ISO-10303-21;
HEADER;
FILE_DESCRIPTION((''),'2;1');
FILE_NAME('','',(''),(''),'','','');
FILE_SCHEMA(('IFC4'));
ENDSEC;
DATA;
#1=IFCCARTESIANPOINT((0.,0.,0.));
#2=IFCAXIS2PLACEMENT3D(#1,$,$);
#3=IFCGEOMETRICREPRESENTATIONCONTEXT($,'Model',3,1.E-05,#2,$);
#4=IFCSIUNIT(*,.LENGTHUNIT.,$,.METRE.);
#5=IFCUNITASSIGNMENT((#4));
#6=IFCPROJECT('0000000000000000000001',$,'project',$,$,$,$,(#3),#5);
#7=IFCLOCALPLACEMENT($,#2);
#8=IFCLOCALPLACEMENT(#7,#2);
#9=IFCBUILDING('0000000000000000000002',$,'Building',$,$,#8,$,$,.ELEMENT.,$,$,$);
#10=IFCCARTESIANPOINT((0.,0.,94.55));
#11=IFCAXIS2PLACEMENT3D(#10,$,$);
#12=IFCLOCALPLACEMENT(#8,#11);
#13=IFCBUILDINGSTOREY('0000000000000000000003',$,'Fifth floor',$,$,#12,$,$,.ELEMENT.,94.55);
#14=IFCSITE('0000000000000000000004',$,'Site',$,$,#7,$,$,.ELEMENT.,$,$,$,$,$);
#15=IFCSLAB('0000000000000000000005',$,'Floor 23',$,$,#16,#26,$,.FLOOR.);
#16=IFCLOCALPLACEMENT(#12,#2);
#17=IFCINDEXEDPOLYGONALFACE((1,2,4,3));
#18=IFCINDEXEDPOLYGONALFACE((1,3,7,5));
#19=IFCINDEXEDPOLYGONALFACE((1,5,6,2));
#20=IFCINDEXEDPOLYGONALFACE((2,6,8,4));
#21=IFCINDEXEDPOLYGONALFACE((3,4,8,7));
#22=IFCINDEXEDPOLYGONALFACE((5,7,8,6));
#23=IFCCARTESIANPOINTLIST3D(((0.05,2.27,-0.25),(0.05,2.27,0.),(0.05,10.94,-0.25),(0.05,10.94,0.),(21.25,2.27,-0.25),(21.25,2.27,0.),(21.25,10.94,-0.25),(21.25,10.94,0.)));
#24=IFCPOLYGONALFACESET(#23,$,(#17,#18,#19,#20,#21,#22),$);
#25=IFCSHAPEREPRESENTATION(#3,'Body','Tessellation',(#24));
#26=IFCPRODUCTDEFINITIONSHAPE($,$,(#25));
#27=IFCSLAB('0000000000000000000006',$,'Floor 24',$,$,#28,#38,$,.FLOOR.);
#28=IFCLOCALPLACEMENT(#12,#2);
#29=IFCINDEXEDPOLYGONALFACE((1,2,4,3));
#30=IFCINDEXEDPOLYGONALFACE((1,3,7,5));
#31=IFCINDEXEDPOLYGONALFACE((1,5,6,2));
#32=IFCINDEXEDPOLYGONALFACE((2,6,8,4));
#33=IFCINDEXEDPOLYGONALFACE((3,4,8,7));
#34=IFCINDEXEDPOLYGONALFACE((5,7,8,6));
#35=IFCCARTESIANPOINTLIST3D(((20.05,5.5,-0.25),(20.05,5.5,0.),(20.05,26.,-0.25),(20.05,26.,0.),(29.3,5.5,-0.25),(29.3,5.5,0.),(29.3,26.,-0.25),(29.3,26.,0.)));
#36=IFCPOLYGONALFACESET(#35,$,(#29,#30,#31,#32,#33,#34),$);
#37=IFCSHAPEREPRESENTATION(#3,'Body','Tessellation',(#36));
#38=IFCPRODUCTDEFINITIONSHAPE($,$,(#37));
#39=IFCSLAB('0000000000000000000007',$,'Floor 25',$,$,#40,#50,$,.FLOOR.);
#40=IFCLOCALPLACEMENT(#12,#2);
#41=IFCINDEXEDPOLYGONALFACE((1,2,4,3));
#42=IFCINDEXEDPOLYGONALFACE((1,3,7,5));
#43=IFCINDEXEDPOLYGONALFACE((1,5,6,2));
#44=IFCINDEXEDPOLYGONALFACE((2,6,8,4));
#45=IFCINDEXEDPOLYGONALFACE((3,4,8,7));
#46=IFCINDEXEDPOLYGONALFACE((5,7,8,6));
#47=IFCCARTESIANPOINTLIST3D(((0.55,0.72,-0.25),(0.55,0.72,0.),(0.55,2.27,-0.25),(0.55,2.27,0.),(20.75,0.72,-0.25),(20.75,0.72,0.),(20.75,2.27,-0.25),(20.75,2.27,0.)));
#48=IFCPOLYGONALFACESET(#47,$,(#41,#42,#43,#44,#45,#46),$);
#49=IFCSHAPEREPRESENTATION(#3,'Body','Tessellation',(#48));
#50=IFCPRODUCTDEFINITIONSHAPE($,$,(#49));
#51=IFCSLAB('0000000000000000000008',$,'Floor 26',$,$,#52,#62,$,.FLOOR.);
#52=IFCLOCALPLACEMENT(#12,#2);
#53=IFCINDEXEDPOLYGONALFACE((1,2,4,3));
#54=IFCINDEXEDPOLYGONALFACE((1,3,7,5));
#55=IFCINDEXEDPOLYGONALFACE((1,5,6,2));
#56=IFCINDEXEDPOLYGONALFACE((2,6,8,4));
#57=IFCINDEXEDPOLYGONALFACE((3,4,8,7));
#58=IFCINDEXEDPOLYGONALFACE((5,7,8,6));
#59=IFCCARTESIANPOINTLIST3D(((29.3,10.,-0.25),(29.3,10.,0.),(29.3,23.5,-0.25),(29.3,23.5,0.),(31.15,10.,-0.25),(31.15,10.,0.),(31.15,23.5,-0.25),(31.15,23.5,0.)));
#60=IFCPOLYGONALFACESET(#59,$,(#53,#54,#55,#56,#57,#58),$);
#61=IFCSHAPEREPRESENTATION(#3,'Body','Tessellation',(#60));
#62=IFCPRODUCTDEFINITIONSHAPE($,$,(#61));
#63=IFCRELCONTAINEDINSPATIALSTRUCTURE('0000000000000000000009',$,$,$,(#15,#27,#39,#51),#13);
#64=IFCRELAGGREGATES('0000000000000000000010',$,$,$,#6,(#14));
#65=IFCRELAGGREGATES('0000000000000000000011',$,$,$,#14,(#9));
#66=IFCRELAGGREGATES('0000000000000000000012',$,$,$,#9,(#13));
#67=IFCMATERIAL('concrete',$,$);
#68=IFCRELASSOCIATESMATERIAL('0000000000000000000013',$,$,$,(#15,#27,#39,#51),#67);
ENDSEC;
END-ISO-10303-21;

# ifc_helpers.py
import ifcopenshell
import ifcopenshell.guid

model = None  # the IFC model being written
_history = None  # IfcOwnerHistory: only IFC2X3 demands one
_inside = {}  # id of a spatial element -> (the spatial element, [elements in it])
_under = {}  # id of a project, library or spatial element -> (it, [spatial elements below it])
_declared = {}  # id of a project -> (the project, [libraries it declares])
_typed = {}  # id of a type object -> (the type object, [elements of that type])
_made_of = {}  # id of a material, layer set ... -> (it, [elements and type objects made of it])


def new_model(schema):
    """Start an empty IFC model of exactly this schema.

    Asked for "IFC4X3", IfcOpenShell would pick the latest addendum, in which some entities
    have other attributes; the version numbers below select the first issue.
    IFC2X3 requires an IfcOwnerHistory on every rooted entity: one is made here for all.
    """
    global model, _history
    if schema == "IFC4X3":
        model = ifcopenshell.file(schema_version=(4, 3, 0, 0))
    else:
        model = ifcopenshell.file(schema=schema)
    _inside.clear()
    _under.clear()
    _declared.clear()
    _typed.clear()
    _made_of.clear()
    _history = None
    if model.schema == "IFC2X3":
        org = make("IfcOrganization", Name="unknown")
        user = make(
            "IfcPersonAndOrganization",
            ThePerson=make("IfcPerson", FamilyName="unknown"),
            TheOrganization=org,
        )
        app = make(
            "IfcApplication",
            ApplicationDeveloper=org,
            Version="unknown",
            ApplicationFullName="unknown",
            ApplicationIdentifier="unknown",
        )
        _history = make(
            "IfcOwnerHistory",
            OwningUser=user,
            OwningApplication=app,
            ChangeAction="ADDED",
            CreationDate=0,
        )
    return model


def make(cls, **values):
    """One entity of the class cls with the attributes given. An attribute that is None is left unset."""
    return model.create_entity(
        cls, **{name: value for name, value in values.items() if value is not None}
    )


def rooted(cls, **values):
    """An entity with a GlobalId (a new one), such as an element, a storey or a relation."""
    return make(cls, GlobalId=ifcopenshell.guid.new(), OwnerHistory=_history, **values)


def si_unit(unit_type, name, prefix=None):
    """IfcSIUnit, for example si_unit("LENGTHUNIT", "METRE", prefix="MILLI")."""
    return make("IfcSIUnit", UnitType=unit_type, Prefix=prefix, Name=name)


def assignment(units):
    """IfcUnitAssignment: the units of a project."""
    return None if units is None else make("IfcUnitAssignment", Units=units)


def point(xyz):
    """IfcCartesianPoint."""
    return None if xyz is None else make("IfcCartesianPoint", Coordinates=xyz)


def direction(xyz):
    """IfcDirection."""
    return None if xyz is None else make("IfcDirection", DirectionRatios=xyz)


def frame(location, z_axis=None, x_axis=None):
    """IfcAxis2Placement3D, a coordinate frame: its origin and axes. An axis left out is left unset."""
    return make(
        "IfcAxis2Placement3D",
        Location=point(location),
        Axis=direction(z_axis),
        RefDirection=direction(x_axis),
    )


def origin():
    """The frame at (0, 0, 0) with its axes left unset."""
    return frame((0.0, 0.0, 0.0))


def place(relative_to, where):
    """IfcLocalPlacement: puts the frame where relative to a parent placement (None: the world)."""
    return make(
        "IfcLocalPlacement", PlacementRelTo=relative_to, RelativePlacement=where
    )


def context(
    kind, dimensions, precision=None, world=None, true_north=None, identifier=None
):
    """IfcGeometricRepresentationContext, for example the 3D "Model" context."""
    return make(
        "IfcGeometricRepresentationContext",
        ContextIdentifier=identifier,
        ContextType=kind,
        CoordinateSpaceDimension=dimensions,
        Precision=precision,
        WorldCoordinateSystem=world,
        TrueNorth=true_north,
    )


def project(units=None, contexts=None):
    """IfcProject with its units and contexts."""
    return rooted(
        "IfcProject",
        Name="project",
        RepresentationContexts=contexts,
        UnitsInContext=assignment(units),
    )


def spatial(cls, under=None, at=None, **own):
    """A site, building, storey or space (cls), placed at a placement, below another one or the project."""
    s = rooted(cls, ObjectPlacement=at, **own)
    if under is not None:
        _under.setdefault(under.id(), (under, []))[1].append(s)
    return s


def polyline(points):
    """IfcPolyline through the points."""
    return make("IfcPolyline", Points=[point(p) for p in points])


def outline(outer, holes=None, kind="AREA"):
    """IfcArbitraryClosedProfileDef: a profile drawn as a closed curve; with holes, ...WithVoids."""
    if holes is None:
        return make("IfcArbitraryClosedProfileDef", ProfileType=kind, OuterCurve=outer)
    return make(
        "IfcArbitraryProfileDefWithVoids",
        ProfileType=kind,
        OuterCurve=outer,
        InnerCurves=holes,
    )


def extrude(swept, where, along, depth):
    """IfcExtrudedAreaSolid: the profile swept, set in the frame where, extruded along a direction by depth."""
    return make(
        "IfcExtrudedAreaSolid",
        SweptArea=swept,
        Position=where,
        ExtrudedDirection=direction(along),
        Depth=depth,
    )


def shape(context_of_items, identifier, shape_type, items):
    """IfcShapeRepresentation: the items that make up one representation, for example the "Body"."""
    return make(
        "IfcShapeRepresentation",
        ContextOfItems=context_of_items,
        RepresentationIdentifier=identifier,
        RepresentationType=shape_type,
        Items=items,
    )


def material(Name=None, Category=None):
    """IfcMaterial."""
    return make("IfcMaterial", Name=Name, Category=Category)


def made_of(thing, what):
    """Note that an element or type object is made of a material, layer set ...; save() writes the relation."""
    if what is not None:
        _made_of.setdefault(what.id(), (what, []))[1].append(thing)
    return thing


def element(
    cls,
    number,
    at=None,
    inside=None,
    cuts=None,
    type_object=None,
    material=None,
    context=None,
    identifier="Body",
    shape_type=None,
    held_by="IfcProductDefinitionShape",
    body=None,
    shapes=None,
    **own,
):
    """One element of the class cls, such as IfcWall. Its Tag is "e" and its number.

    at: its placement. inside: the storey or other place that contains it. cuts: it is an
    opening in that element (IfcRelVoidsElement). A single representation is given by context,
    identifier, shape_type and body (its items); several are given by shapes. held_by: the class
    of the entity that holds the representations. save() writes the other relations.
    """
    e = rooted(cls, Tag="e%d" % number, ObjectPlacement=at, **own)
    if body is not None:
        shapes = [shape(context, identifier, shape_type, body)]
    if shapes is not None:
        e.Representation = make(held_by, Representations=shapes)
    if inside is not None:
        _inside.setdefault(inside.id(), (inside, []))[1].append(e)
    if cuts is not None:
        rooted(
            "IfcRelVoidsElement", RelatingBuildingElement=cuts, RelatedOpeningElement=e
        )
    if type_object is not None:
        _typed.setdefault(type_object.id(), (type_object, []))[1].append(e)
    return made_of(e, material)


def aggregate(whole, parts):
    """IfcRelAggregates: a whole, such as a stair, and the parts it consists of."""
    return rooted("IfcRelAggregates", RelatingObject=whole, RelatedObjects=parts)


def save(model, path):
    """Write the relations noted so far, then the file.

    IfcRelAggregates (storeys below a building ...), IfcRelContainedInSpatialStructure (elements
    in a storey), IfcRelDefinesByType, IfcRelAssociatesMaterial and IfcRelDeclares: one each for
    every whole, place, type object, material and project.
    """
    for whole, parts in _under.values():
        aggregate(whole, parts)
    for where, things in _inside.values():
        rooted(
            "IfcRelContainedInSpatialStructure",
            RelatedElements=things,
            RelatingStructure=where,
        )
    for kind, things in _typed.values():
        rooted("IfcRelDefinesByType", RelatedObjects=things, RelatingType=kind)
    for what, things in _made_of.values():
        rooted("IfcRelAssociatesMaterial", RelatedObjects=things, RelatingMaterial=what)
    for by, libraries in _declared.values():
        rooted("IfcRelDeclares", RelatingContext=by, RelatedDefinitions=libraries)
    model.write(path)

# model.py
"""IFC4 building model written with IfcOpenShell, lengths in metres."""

from ifc_helpers import new_model, si_unit, frame, origin, place, context, project, spatial, polyline, outline, extrude, material, element, save


model = new_model("IFC4")

# Units and contexts
model_context = context("Model", 3, precision=1e-05, world=origin())
ifc_project = project(units=[si_unit("LENGTHUNIT", "METRE")], contexts=[model_context])

# Site, building, storey
site_placement = place(None, origin())
site = spatial("IfcSite", under=ifc_project, at=site_placement, Name="Site", CompositionType="ELEMENT")
building_placement = place(site_placement, origin())
building = spatial("IfcBuilding", under=site, at=building_placement, Name="Building", CompositionType="ELEMENT")
storey_placement = place(building_placement, frame((0.0, 0.0, 94.55)))
storey = spatial("IfcBuildingStorey", under=building, at=storey_placement, Name="Fifth floor", CompositionType="ELEMENT", Elevation=94.55)

# Slabs
ifc_material = material(Name="concrete")
slab_1_placement = place(storey_placement, frame((0.0, 0.0, -0.25), z_axis=(0.0, 0.0, 1.0), x_axis=(1.0, 0.0, 0.0)))
element("IfcSlab", 1, at=slab_1_placement, inside=storey, material=ifc_material, Name="Floor 23", PredefinedType="FLOOR", context=model_context, shape_type="SweptSolid", body=[
    extrude(outline(polyline([(0.05, 2.27), (21.25, 2.27), (21.25, 10.94), (0.05, 10.94), (0.05, 2.27)])), origin(), (0.0, 0.0, 1.0), 0.25),
])
slab_2_placement = place(storey_placement, frame((0.0, 0.0, -0.25), z_axis=(0.0, 0.0, 1.0), x_axis=(1.0, 0.0, 0.0)))
element("IfcSlab", 2, at=slab_2_placement, inside=storey, material=ifc_material, Name="Floor 24", PredefinedType="FLOOR", context=model_context, shape_type="SweptSolid", body=[
    extrude(outline(polyline([(20.05, 5.5), (29.3, 5.5), (29.3, 26.0), (20.05, 26.0), (20.05, 5.5)])), origin(), (0.0, 0.0, 1.0), 0.25),
])
slab_3_placement = place(storey_placement, frame((0.0, 0.0, -0.25), z_axis=(0.0, 0.0, 1.0), x_axis=(1.0, 0.0, 0.0)))
element("IfcSlab", 3, at=slab_3_placement, inside=storey, material=ifc_material, Name="Floor 25", PredefinedType="FLOOR", context=model_context, shape_type="SweptSolid", body=[
    extrude(outline(polyline([(0.55, 0.72), (20.75, 0.72), (20.75, 2.27), (0.55, 2.27), (0.55, 0.72)])), origin(), (0.0, 0.0, 1.0), 0.25),
])
slab_4_placement = place(storey_placement, frame((0.0, 0.0, -0.25), z_axis=(0.0, 0.0, 1.0), x_axis=(1.0, 0.0, 0.0)))
element("IfcSlab", 4, at=slab_4_placement, inside=storey, material=ifc_material, Name="Floor 26", PredefinedType="FLOOR", context=model_context, shape_type="SweptSolid", body=[
    extrude(outline(polyline([(29.3, 10.0), (31.15, 10.0), (31.15, 23.5), (29.3, 23.5), (29.3, 10.0)])), origin(), (0.0, 0.0, 1.0), 0.25),
])

save(model, "model.ifc")
